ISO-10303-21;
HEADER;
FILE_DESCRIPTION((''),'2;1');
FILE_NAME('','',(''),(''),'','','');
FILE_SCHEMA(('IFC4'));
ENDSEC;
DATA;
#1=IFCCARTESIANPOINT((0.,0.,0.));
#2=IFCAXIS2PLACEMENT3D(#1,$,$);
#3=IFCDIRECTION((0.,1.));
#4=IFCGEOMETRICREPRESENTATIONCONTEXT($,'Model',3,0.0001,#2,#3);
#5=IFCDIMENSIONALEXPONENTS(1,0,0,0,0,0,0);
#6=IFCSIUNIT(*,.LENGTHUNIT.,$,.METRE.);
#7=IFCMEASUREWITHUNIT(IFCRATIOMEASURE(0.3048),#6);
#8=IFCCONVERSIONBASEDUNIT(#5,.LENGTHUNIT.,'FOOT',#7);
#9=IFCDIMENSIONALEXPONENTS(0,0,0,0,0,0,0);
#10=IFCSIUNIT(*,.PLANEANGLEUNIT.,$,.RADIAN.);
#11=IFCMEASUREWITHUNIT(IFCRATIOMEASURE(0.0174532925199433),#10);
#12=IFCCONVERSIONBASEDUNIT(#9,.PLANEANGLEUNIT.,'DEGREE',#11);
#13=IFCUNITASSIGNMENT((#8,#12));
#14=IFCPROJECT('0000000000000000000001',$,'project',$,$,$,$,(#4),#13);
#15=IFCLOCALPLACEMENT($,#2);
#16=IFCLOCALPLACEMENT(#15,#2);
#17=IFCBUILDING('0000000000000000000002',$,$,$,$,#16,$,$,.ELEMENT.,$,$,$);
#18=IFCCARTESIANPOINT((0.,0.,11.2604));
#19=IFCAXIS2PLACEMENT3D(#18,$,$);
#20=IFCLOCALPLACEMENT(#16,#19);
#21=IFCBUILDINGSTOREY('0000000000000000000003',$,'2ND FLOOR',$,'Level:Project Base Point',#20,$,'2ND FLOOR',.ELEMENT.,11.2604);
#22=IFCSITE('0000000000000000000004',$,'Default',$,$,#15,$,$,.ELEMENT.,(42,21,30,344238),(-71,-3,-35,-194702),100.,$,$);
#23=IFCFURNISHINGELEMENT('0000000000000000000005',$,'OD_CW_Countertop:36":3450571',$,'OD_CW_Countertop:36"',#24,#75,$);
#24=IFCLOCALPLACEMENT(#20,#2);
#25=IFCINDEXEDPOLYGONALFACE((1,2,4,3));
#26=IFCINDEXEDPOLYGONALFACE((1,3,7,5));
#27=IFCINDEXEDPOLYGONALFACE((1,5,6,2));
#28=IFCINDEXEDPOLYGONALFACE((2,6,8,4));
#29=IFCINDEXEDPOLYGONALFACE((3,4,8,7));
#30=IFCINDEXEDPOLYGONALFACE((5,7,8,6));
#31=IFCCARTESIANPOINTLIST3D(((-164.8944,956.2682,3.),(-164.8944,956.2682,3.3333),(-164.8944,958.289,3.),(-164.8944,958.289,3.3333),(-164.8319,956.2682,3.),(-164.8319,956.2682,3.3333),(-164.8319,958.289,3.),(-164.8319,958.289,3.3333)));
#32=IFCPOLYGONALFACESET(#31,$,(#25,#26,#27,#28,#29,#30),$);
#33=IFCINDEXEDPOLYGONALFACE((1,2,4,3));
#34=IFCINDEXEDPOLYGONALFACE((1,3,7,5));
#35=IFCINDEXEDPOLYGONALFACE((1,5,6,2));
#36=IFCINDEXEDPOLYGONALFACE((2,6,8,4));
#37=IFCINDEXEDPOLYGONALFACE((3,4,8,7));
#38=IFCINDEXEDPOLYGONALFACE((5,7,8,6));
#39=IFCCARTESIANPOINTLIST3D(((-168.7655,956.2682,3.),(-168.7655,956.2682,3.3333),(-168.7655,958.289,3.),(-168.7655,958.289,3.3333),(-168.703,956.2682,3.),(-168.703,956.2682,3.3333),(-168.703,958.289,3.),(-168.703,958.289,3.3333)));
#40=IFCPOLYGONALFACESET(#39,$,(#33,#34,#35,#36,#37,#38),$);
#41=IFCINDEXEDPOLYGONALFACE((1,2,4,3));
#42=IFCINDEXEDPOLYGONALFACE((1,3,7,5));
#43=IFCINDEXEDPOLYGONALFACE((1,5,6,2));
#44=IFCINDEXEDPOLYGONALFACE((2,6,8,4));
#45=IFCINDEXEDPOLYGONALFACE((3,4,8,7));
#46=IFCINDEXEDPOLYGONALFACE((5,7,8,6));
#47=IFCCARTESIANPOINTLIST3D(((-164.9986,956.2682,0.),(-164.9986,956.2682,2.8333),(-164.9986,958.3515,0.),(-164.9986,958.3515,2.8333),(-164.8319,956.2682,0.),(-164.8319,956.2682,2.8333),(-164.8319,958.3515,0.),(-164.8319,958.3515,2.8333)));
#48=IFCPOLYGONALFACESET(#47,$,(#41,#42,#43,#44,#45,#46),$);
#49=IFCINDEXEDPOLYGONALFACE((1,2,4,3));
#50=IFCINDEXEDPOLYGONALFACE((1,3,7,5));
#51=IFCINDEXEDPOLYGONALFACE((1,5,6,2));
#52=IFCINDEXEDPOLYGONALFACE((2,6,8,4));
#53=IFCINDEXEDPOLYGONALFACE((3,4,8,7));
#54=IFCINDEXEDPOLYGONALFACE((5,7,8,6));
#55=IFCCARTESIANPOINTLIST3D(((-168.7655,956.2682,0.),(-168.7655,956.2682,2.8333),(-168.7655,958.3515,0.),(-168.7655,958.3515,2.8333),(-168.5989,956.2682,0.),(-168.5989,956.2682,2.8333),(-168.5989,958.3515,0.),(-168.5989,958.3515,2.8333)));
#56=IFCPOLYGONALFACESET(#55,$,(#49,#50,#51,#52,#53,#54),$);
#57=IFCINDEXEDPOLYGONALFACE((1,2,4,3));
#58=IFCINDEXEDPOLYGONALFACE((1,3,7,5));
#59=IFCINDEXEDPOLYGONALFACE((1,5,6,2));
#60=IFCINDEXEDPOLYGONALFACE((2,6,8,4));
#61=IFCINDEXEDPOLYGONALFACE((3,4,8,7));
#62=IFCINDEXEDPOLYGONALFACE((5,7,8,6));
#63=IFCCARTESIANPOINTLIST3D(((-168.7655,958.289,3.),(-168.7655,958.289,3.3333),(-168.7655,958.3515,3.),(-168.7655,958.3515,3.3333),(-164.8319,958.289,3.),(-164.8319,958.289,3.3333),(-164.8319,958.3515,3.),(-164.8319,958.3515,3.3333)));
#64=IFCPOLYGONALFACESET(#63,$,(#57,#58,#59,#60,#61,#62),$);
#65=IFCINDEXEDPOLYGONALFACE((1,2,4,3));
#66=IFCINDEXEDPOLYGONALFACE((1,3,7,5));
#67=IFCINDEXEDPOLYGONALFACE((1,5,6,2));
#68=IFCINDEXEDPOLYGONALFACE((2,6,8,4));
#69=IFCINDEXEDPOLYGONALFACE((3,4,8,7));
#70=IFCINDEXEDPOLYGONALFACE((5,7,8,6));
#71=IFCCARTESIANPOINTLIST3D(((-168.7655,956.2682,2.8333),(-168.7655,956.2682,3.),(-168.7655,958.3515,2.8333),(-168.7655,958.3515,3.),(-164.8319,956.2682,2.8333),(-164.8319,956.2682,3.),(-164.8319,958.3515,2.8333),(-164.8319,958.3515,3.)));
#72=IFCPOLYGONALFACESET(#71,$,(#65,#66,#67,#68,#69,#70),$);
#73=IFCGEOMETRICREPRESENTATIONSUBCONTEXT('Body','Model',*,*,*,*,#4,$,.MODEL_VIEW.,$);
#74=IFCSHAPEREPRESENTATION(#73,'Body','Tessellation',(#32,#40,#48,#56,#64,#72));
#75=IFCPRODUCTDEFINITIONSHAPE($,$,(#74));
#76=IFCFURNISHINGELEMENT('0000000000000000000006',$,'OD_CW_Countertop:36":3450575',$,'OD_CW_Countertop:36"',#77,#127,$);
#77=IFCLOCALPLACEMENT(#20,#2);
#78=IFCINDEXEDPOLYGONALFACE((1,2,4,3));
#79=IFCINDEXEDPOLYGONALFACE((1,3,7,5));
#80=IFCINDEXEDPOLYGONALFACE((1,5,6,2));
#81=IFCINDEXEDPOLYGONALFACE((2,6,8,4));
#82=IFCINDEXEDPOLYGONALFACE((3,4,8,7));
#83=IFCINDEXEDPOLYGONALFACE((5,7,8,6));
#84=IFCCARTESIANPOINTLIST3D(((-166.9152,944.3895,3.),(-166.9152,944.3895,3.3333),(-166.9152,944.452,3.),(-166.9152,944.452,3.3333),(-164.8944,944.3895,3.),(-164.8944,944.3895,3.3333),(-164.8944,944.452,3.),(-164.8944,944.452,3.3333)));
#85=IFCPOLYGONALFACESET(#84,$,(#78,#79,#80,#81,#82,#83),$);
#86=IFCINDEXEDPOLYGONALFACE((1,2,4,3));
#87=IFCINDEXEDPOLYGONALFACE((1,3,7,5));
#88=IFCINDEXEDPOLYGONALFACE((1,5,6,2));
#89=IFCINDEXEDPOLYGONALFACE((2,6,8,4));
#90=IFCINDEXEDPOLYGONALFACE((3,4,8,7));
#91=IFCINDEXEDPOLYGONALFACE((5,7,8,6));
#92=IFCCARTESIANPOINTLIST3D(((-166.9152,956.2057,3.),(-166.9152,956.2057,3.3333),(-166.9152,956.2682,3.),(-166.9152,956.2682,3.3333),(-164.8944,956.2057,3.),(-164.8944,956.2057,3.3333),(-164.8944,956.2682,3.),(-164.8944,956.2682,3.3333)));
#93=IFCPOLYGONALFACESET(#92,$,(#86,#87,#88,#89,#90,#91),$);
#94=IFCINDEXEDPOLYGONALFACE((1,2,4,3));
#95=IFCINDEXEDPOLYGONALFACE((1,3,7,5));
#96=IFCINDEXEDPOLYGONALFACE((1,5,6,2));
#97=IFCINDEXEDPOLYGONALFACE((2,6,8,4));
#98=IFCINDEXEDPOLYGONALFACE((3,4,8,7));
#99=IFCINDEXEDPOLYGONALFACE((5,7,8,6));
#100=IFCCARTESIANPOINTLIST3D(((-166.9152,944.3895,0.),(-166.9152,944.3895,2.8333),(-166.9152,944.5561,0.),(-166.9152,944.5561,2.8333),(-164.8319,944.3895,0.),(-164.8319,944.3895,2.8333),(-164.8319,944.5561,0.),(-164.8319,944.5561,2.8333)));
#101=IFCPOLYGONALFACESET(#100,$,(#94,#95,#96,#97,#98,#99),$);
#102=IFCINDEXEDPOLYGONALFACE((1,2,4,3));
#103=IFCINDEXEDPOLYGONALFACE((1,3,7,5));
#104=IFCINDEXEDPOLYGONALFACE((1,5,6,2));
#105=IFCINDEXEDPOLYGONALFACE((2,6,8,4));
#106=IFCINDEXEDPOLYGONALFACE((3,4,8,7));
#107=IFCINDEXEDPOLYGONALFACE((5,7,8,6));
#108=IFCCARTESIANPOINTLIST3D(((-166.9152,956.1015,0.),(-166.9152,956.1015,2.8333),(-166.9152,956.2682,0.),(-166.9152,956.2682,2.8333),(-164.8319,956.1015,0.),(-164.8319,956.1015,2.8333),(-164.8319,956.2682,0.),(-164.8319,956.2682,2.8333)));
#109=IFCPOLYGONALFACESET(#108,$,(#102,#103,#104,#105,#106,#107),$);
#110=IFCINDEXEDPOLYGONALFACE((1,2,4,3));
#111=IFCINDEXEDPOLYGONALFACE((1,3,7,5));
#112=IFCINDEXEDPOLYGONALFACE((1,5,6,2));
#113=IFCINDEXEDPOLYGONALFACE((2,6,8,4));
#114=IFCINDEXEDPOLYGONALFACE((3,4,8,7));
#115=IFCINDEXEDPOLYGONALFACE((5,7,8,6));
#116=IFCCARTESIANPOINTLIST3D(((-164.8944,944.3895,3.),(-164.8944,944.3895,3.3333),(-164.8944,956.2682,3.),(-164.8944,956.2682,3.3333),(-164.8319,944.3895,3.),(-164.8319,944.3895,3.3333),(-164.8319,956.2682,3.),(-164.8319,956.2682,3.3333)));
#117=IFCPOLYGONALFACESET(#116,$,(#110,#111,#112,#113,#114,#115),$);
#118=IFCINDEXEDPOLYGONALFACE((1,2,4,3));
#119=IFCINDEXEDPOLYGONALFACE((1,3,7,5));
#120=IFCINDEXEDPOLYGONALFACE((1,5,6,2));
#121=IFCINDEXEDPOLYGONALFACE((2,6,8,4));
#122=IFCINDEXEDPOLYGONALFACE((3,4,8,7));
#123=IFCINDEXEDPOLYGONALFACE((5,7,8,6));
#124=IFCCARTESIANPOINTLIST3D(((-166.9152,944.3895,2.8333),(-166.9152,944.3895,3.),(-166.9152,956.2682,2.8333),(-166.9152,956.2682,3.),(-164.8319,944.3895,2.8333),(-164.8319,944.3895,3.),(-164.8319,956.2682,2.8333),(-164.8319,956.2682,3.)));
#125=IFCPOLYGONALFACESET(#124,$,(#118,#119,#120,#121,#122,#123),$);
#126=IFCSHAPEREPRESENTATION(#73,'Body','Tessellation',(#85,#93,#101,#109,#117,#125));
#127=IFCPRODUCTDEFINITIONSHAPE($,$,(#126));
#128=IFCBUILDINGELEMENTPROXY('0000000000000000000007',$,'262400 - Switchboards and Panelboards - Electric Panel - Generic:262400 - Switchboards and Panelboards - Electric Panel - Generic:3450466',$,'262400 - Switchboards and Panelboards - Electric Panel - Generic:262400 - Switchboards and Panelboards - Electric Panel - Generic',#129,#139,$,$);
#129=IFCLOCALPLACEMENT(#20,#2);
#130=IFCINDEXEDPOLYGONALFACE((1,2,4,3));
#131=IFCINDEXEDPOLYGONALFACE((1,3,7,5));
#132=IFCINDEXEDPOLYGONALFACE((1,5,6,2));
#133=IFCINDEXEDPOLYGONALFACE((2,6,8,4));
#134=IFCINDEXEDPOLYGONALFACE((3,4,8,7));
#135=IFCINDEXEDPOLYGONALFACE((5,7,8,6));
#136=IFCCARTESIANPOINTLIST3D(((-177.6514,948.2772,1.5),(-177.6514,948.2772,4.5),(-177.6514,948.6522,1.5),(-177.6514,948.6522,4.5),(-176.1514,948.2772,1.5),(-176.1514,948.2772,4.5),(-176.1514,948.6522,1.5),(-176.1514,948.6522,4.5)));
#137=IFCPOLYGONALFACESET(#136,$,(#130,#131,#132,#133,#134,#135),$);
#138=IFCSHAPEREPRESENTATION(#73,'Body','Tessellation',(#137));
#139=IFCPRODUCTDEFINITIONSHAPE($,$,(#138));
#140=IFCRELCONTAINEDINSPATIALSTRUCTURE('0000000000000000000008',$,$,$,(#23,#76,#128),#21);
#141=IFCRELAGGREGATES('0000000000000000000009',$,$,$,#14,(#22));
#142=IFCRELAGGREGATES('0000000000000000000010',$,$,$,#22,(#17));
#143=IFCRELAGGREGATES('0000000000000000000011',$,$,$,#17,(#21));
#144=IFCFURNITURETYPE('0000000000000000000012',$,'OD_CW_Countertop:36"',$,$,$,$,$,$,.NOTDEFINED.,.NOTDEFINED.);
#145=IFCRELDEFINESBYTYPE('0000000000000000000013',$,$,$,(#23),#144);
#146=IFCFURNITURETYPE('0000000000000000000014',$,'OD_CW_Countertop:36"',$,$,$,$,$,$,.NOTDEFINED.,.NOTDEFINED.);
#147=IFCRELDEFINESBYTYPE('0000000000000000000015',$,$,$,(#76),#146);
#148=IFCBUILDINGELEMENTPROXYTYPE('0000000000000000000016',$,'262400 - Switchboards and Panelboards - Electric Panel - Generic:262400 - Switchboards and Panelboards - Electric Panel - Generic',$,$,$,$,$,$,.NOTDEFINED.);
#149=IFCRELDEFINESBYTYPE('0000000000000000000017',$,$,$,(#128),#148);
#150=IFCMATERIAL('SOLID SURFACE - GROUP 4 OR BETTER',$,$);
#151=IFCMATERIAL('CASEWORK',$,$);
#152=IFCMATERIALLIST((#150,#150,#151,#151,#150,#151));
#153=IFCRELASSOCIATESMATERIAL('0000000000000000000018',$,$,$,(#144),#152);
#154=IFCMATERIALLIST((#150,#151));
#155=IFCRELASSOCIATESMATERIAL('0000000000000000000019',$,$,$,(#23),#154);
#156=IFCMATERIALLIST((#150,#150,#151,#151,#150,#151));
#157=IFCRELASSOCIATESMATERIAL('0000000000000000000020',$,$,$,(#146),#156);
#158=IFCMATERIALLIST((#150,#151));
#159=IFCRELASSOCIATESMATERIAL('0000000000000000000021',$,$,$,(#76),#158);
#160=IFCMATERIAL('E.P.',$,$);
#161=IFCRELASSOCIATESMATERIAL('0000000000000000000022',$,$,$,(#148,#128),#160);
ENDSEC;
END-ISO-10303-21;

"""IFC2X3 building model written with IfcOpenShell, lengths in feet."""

from ifc_helpers import new_model, entity, si_unit, converted_unit, direction, frame, frame_2d, origin, origin_2d_with_axis, place, context, subcontext, project, spatial, rectangle, extrude, source, transform, mapped, material, material_list, type_object, type_shapes, element, save


model = new_model("IFC2X3")

# Units and contexts
model_context = context("Model", 3, precision=0.0001, world=origin(), true_north=direction((0.0, 1.0)))
body_context = subcontext(model_context, "Body", "Model", "MODEL_VIEW")
ifc_project = project(units=[converted_unit("LENGTHUNIT", "FOOT", entity("IfcRatioMeasure", 0.3048), si_unit("LENGTHUNIT", "METRE"), dimensions=[1, 0, 0, 0, 0, 0, 0]), converted_unit("PLANEANGLEUNIT", "DEGREE", entity("IfcRatioMeasure", 0.0174532925199433), si_unit("PLANEANGLEUNIT", "RADIAN"), dimensions=[0, 0, 0, 0, 0, 0, 0])], contexts=[model_context])

# Site, building, storey
site_placement = place(None, origin())
site = spatial("IfcSite", under=ifc_project, at=site_placement, Name="Default", CompositionType="ELEMENT", RefLatitude=(42, 21, 30, 344238), RefLongitude=(-71, -3, -35, -194702), RefElevation=100.0)
building_placement = place(site_placement, origin())
building = spatial("IfcBuilding", under=site, at=building_placement, CompositionType="ELEMENT")
storey_placement = place(building_placement, frame((0.0, 0.0, 11.2604)))
storey = spatial("IfcBuildingStorey", under=building, at=storey_placement, Name="2ND FLOOR", ObjectType="Level:Project Base Point", LongName="2ND FLOOR", CompositionType="ELEMENT", Elevation=11.2604)

# Furnishing elements
ifc_material_1 = material(Name="CASEWORK")
ifc_material_2 = material(Name="SOLID SURFACE - GROUP 4 OR BETTER")
ifc_material_list_1 = material_list([ifc_material_2, ifc_material_1])
ifc_material_list_2 = material_list([ifc_material_2, ifc_material_2, ifc_material_1, ifc_material_1, ifc_material_2, ifc_material_1])
furniture_type_1 = type_object("IfcFurnitureType", Name="OD_CW_Countertop:36\"", material=ifc_material_list_2)
shared_shape_1 = source(origin(), body_context, "Body", "SweptSolid", [
    extrude(rectangle(XDim=0.0625, YDim=2.0208, at=origin_2d_with_axis()), frame((3.9024, 1.0104, 3.0), z_axis=(0.0, 0.0, 1.0), x_axis=(-1.0, 0.0, 0.0)), (0.0, 0.0, 1.0), 0.3333),
    extrude(rectangle(XDim=0.0625, YDim=2.0208, at=origin_2d_with_axis()), frame((0.0313, 1.0104, 3.0), z_axis=(0.0, 0.0, 1.0), x_axis=(-1.0, 0.0, 0.0)), (0.0, 0.0, 1.0), 0.3333),
    extrude(rectangle(XDim=2.0833, YDim=0.1667, at=frame_2d((0.0, 0.0), x_axis=(1.0, 0.0))), frame((3.8503, 1.0417, 0.0), z_axis=(0.0, 0.0, 1.0), x_axis=(0.0, -1.0, 0.0)), (0.0, 0.0, 1.0), 2.8333),
    extrude(rectangle(XDim=2.0833, YDim=0.1667, at=origin_2d_with_axis()), frame((0.0833, 1.0417, 0.0), z_axis=(0.0, 0.0, 1.0), x_axis=(0.0, -1.0, 0.0)), (0.0, 0.0, 1.0), 2.8333),
    extrude(rectangle(XDim=0.0625, YDim=3.9336, at=frame_2d((0.0, 0.0), x_axis=(1.0, 0.0))), frame((1.9668, 2.0521, 3.0), z_axis=(0.0, 0.0, 1.0), x_axis=(0.0, -1.0, 0.0)), (0.0, 0.0, 1.0), 0.3333),
    extrude(rectangle(XDim=2.0833, YDim=3.9336, at=origin_2d_with_axis()), frame((1.9668, 1.0417, 2.8333), z_axis=(0.0, 0.0, 1.0), x_axis=(0.0, -1.0, 0.0)), (0.0, 0.0, 1.0), 0.1667),
])
type_shapes(furniture_type_1, [shared_shape_1])
furnishing_1_placement = place(storey_placement, frame((-168.7655, 956.2682, 0.0)))
element("IfcFurnishingElement", 1, at=furnishing_1_placement, inside=storey, type_object=furniture_type_1, material=ifc_material_list_1, Name="OD_CW_Countertop:36\":3450571", ObjectType="OD_CW_Countertop:36\"", context=body_context, shape_type="MappedRepresentation", body=[
    mapped(shared_shape_1, transform((0.0, 0.0, 0.0), scale=1.0)),
])
ifc_material_list_3 = material_list([ifc_material_2, ifc_material_1])
ifc_material_list_4 = material_list([ifc_material_2, ifc_material_2, ifc_material_1, ifc_material_1, ifc_material_2, ifc_material_1])
furniture_type_2 = type_object("IfcFurnitureType", Name="OD_CW_Countertop:36\"", material=ifc_material_list_4)
shared_shape_2 = source(origin(), body_context, "Body", "SweptSolid", [
    extrude(rectangle(XDim=0.0625, YDim=2.0208, at=origin_2d_with_axis()), frame((11.8475, 1.0104, 3.0), z_axis=(0.0, 0.0, 1.0), x_axis=(-1.0, 0.0, 0.0)), (0.0, 0.0, 1.0), 0.3333),
    extrude(rectangle(XDim=0.0625, YDim=2.0208, at=origin_2d_with_axis()), frame((0.0313, 1.0104, 3.0), z_axis=(0.0, 0.0, 1.0), x_axis=(-1.0, 0.0, 0.0)), (0.0, 0.0, 1.0), 0.3333),
    extrude(rectangle(XDim=2.0833, YDim=0.1667, at=frame_2d((0.0, 0.0), x_axis=(1.0, 0.0))), frame((11.7954, 1.0417, 0.0), z_axis=(0.0, 0.0, 1.0), x_axis=(0.0, -1.0, 0.0)), (0.0, 0.0, 1.0), 2.8333),
    extrude(rectangle(XDim=2.0833, YDim=0.1667, at=origin_2d_with_axis()), frame((0.0833, 1.0417, 0.0), z_axis=(0.0, 0.0, 1.0), x_axis=(0.0, -1.0, 0.0)), (0.0, 0.0, 1.0), 2.8333),
    extrude(rectangle(XDim=0.0625, YDim=11.8787, at=frame_2d((0.0, 0.0), x_axis=(1.0, 0.0))), frame((5.9394, 2.0521, 3.0), z_axis=(0.0, 0.0, 1.0), x_axis=(0.0, -1.0, 0.0)), (0.0, 0.0, 1.0), 0.3333),
    extrude(rectangle(XDim=2.0833, YDim=11.8787, at=frame_2d((0.0, 0.0), x_axis=(1.0, 0.0))), frame((5.9394, 1.0417, 2.8333), z_axis=(0.0, 0.0, 1.0), x_axis=(0.0, -1.0, 0.0)), (0.0, 0.0, 1.0), 0.1667),
])
type_shapes(furniture_type_2, [shared_shape_2])
furnishing_2_placement = place(storey_placement, frame((-166.9152, 956.2682, 0.0), z_axis=(0.0, 0.0, 1.0), x_axis=(0.0, -1.0, 0.0)))
element("IfcFurnishingElement", 2, at=furnishing_2_placement, inside=storey, type_object=furniture_type_2, material=ifc_material_list_3, Name="OD_CW_Countertop:36\":3450575", ObjectType="OD_CW_Countertop:36\"", context=body_context, shape_type="MappedRepresentation", body=[
    mapped(shared_shape_2, transform((0.0, 0.0, 0.0), scale=1.0)),
])

# Building element proxy
ifc_material_3 = material(Name="E.P.")
building_element_proxy_type_1 = type_object("IfcBuildingElementProxyType", Name="262400 - Switchboards and Panelboards - Electric Panel - Generic:262400 - Switchboards and Panelboards - Electric Panel - Generic", PredefinedType="NOTDEFINED", material=ifc_material_3)
shared_shape_3 = source(origin(), body_context, "Body", "SweptSolid", [
    extrude(rectangle(XDim=0.375, YDim=1.5, at=origin_2d_with_axis()), frame((0.75, 0.1875, 0.0), z_axis=(0.0, 0.0, 1.0), x_axis=(0.0, 1.0, 0.0)), (0.0, 0.0, 1.0), 3.0),
])
type_shapes(building_element_proxy_type_1, [shared_shape_3])
proxy_1_placement = place(storey_placement, frame((-177.6514, 948.2772, 1.5)))
element("IfcBuildingElementProxy", 3, at=proxy_1_placement, inside=storey, type_object=building_element_proxy_type_1, material=ifc_material_3, Name="262400 - Switchboards and Panelboards - Electric Panel - Generic:262400 - Switchboards and Panelboards - Electric Panel - Generic:3450466", ObjectType="262400 - Switchboards and Panelboards - Electric Panel - Generic:262400 - Switchboards and Panelboards - Electric Panel - Generic", context=body_context, shape_type="MappedRepresentation", body=[
    mapped(shared_shape_3, transform((0.0, 0.0, 0.0), scale=1.0)),
])

save(model, "model.ifc")
